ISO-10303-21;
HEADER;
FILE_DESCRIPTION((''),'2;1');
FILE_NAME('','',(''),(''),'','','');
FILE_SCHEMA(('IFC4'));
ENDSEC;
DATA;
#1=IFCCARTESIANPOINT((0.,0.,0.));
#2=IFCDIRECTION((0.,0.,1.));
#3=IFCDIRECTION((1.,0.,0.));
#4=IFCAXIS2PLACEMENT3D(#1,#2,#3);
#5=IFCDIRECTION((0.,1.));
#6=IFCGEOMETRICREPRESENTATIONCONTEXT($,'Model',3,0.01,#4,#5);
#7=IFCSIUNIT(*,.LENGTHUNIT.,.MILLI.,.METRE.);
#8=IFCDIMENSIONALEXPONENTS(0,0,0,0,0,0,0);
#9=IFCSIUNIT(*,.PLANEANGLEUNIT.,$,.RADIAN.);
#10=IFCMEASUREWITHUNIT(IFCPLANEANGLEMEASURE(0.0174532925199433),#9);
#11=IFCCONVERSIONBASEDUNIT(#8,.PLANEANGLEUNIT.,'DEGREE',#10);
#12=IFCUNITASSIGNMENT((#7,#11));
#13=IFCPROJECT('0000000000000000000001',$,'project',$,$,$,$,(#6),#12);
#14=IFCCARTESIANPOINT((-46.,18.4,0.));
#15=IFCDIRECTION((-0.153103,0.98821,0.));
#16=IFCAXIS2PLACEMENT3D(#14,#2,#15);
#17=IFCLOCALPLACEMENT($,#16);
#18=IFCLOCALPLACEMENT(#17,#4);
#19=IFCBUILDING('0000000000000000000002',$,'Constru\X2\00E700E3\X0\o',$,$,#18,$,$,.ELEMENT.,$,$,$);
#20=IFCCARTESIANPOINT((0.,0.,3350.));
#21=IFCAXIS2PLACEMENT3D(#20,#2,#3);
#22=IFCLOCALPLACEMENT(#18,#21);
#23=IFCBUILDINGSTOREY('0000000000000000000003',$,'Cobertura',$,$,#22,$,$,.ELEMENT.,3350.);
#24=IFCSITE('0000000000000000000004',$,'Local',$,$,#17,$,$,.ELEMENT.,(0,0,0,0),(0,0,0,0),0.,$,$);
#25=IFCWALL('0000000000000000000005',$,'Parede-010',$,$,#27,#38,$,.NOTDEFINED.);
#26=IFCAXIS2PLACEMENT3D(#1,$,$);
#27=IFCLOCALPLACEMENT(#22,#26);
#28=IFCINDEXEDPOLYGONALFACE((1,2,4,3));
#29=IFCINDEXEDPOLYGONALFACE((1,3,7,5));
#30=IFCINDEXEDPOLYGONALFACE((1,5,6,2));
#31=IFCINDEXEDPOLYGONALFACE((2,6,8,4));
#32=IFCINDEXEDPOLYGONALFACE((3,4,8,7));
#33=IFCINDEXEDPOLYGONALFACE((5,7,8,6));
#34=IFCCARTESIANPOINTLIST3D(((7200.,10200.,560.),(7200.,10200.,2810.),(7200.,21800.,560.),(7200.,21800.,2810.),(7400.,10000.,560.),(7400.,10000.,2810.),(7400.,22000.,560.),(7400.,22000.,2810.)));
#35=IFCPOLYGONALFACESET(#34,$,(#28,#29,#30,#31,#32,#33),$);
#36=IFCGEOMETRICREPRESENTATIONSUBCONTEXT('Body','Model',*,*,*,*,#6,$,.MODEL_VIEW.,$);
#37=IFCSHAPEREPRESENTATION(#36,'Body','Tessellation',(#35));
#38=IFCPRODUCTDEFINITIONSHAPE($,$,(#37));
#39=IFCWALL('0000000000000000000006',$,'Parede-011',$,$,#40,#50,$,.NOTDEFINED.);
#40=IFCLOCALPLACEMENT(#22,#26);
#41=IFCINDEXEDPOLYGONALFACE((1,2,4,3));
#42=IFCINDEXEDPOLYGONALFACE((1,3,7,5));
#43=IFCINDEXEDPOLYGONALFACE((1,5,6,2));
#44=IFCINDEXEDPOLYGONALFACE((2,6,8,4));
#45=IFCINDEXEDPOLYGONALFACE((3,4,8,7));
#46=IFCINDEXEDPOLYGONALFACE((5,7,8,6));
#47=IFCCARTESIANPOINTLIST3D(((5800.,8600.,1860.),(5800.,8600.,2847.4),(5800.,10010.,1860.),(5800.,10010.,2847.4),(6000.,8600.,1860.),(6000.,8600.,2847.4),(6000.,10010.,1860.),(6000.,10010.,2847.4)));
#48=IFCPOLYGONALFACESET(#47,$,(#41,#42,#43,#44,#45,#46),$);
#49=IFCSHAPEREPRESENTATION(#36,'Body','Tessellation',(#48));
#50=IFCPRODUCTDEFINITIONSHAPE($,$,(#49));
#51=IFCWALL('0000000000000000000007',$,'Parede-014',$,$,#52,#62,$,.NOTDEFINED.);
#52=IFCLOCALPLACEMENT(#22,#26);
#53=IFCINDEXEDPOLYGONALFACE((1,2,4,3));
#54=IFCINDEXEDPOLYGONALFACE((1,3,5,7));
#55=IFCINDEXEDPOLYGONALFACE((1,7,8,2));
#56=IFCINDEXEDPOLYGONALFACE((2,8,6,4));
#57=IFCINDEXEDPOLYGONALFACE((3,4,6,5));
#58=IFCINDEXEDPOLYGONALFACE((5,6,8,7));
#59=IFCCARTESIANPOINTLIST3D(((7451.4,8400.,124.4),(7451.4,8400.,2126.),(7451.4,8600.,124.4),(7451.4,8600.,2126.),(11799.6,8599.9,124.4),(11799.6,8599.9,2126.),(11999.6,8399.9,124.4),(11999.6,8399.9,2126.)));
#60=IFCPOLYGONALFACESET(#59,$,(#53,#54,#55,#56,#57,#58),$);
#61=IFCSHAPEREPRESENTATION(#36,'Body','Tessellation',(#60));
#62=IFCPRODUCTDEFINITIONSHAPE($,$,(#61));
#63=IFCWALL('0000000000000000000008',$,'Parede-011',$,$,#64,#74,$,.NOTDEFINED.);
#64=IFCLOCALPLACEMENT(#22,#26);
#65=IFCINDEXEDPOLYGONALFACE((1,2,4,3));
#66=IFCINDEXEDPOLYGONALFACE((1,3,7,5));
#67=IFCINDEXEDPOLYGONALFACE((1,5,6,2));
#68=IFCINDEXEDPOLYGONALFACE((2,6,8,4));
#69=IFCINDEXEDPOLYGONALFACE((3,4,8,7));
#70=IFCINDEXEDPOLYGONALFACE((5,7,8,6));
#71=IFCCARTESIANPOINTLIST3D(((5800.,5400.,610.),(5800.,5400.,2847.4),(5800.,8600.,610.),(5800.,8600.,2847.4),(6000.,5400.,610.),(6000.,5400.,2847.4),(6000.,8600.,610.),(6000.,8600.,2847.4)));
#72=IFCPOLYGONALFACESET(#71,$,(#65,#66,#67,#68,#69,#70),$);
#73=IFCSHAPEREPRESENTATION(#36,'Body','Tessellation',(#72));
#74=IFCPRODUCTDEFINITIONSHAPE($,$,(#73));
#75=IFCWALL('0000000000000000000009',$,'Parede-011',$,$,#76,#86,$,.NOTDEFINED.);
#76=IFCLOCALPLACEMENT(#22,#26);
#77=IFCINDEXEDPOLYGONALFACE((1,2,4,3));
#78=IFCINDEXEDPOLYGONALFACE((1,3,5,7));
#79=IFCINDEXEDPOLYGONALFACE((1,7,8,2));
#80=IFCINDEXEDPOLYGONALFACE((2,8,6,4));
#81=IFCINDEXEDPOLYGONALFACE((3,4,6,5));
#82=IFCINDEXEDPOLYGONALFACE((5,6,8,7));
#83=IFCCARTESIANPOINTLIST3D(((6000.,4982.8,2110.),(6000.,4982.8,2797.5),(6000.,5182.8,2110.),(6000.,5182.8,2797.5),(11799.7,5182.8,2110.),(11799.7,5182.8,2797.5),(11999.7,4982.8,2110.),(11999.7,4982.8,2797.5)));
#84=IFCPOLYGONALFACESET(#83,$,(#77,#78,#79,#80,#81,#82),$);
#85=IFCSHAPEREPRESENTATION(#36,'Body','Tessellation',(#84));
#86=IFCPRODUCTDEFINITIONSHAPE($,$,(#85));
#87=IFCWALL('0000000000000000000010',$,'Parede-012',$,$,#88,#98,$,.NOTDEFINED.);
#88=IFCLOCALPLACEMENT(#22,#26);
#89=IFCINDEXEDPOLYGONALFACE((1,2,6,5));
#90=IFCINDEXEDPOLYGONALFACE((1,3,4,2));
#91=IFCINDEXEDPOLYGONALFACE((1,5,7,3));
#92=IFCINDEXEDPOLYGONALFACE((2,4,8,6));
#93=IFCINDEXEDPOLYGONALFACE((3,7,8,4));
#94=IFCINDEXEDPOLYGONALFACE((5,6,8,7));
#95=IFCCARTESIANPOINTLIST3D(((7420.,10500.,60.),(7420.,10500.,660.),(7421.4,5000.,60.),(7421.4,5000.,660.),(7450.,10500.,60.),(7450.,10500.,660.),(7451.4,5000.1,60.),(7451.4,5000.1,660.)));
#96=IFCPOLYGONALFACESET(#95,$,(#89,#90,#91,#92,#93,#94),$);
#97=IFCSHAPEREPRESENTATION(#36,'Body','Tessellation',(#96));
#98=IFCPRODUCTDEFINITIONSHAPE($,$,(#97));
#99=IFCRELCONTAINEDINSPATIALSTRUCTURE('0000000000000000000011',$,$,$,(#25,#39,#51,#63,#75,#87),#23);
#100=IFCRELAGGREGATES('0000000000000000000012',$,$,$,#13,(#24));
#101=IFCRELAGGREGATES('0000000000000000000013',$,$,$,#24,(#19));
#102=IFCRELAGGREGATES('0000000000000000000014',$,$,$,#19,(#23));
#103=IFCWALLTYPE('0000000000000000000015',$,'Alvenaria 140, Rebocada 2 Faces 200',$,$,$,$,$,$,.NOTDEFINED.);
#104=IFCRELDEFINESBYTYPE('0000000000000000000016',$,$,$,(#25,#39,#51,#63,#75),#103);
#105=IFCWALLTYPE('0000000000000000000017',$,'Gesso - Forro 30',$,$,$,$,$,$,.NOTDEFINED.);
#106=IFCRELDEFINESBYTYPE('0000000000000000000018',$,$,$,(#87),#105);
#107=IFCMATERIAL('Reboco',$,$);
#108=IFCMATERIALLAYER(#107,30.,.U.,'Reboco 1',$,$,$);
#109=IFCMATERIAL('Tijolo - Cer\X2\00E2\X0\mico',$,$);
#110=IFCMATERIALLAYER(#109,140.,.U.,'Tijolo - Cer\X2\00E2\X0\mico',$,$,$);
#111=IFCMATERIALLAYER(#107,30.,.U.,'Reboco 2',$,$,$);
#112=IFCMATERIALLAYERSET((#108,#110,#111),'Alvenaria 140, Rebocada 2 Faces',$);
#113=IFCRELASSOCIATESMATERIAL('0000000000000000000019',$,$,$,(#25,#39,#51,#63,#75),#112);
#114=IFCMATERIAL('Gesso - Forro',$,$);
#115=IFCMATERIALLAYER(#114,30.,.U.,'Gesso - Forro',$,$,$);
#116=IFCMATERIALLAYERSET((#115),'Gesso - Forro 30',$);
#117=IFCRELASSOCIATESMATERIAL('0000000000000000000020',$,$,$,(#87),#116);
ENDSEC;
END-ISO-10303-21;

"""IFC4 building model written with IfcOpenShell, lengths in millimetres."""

from ifc_helpers import new_model, entity, si_unit, converted_unit, direction, frame, origin_with_axes, place, context, subcontext, project, spatial, line, indexed_curve, outline, extrude, material, layer, layer_set, layer_usage, type_object, element, save


model = new_model("IFC4")

# Units and contexts
model_context = context("Model", 3, precision=0.01, world=origin_with_axes(), true_north=direction((0.0, 1.0)))
body_context = subcontext(model_context, "Body", "Model", "MODEL_VIEW")
ifc_project = project(units=[si_unit("LENGTHUNIT", "METRE", prefix="MILLI"), converted_unit("PLANEANGLEUNIT", "DEGREE", entity("IfcPlaneAngleMeasure", 0.0174532925199433), si_unit("PLANEANGLEUNIT", "RADIAN"), dimensions=[0, 0, 0, 0, 0, 0, 0])], contexts=[model_context])

# Site, building, storey
site_placement = place(None, frame((-46.0, 18.4, 0.0), z_axis=(0.0, 0.0, 1.0), x_axis=(-0.153103, 0.98821, 0.0)))
site = spatial("IfcSite", under=ifc_project, at=site_placement, Name="Local", CompositionType="ELEMENT", RefLatitude=(0, 0, 0, 0), RefLongitude=(0, 0, 0, 0), RefElevation=0.0)
building_placement = place(site_placement, origin_with_axes())
building = spatial("IfcBuilding", under=site, at=building_placement, Name="Construção", CompositionType="ELEMENT")
storey_placement = place(building_placement, frame((0.0, 0.0, 3350.0), z_axis=(0.0, 0.0, 1.0), x_axis=(1.0, 0.0, 0.0)))
storey = spatial("IfcBuildingStorey", under=building, at=storey_placement, Name="Cobertura", CompositionType="ELEMENT", Elevation=3350.0)

# Walls
ifc_material_1 = material(Name="Reboco")
ifc_layer_1 = layer(ifc_material_1, 30.0, ventilated="UNKNOWN", Name="Reboco 1")
ifc_material_2 = material(Name="Tijolo - Cerâmico")
ifc_layer_2 = layer(ifc_material_2, 140.0, ventilated="UNKNOWN", Name="Tijolo - Cerâmico")
ifc_layer_3 = layer(ifc_material_1, 30.0, ventilated="UNKNOWN", Name="Reboco 2")
ifc_layer_set_1 = layer_set([ifc_layer_1, ifc_layer_2, ifc_layer_3], Name="Alvenaria 140, Rebocada 2 Faces")
wall_type_1 = type_object("IfcWallType", Name="Alvenaria 140, Rebocada 2 Faces 200", PredefinedType="NOTDEFINED")
ifc_layer_usage_1 = layer_usage(ifc_layer_set_1, "AXIS2", "POSITIVE", 0.0)
wall_1_placement = place(storey_placement, frame((7400.0, 10000.0, 560.0), z_axis=(0.0, 0.0, 1.0), x_axis=(-0.000001, 1.0, 0.0)))
element("IfcWall", 1, at=wall_1_placement, inside=storey, type_object=wall_type_1, material=ifc_layer_usage_1, Name="Parede-010", PredefinedType="NOTDEFINED", context=body_context, shape_type="SweptSolid", body=[
    extrude(outline(indexed_curve([(0.0, 0.0), (12000.0, 0.0), (11800.0, 200.0), (200.0, 200.0)], segments=[line(1, 2, 3, 4, 1)])), origin_with_axes(), (0.0, 0.0, 1.0), 2250.0),
])
ifc_layer_usage_2 = layer_usage(ifc_layer_set_1, "AXIS2", "POSITIVE", 0.0)
wall_2_placement = place(storey_placement, frame((5800.0, 10010.0, 1860.0), z_axis=(0.0, 0.0, 1.0), x_axis=(0.0, -1.0, 0.0)))
element("IfcWall", 2, at=wall_2_placement, inside=storey, type_object=wall_type_1, material=ifc_layer_usage_2, Name="Parede-011", PredefinedType="NOTDEFINED", context=body_context, shape_type="SweptSolid", body=[
    extrude(outline(indexed_curve([(0.0, 0.0), (1410.0, 0.0), (1410.0, 200.0), (0.0, 200.0)], segments=[line(1, 2, 3, 4, 1)])), origin_with_axes(), (0.0, 0.0, 1.0), 987.4),
])
ifc_layer_usage_3 = layer_usage(ifc_layer_set_1, "AXIS2", "NEGATIVE", 0.0)
wall_3_placement = place(storey_placement, frame((11999.6, 8399.9, 124.4), z_axis=(0.0, 0.0, 1.0), x_axis=(-1.0, 0.00003, 0.0)))
element("IfcWall", 3, at=wall_3_placement, inside=storey, type_object=wall_type_1, material=ifc_layer_usage_3, Name="Parede-014", PredefinedType="NOTDEFINED", context=body_context, shape_type="SweptSolid", body=[
    extrude(outline(indexed_curve([(200.0, -200.0), (4548.2, -200.0), (4548.2, 0.0), (0.0, 0.0)], segments=[line(1, 2, 3, 4, 1)])), origin_with_axes(), (0.0, 0.0, 1.0), 2001.6),
])
ifc_layer_usage_4 = layer_usage(ifc_layer_set_1, "AXIS2", "POSITIVE", 0.0)
wall_4_placement = place(storey_placement, frame((5800.0, 8600.0, 610.0), z_axis=(0.0, 0.0, 1.0), x_axis=(0.0, -1.0, 0.0)))
element("IfcWall", 4, at=wall_4_placement, inside=storey, type_object=wall_type_1, material=ifc_layer_usage_4, Name="Parede-011", PredefinedType="NOTDEFINED", context=body_context, shape_type="SweptSolid", body=[
    extrude(outline(indexed_curve([(0.0, 0.0), (3200.0, 0.0), (3200.0, 200.0), (0.0, 200.0)], segments=[line(1, 2, 3, 4, 1)])), origin_with_axes(), (0.0, 0.0, 1.0), 2237.4),
])
ifc_layer_usage_5 = layer_usage(ifc_layer_set_1, "AXIS2", "POSITIVE", 0.0)
wall_5_placement = place(storey_placement, frame((6000.0, 4982.8, 2110.0), z_axis=(0.0, 0.0, 1.0), x_axis=(1.0, 0.0, 0.0)))
element("IfcWall", 5, at=wall_5_placement, inside=storey, type_object=wall_type_1, material=ifc_layer_usage_5, Name="Parede-011", PredefinedType="NOTDEFINED", context=body_context, shape_type="SweptSolid", body=[
    extrude(outline(indexed_curve([(0.0, 0.0), (5999.7, 0.0), (5799.7, 200.0), (0.0, 200.0)], segments=[line(1, 2, 3, 4, 1)])), origin_with_axes(), (0.0, 0.0, 1.0), 687.5),
])
ifc_material_3 = material(Name="Gesso - Forro")
ifc_layer_4 = layer(ifc_material_3, 30.0, ventilated="UNKNOWN", Name="Gesso - Forro")
ifc_layer_set_2 = layer_set([ifc_layer_4], Name="Gesso - Forro 30")
ifc_layer_usage_6 = layer_usage(ifc_layer_set_2, "AXIS2", "NEGATIVE", 0.0)
wall_type_2 = type_object("IfcWallType", Name="Gesso - Forro 30", PredefinedType="NOTDEFINED")
wall_6_placement = place(storey_placement, frame((7450.0, 10500.0, 60.0), z_axis=(0.0, 0.0, 1.0), x_axis=(0.00025, -1.0, 0.0)))
element("IfcWall", 6, at=wall_6_placement, inside=storey, type_object=wall_type_2, material=ifc_layer_usage_6, Name="Parede-012", PredefinedType="NOTDEFINED", context=body_context, shape_type="SweptSolid", body=[
    extrude(outline(indexed_curve([(0.0, -30.0), (5499.9, -30.0), (5499.9, 0.0), (0.0, 0.0)], segments=[line(1, 2, 3, 4, 1)])), origin_with_axes(), (0.0, 0.0, 1.0), 600.0),
])

save(model, "model.ifc")
